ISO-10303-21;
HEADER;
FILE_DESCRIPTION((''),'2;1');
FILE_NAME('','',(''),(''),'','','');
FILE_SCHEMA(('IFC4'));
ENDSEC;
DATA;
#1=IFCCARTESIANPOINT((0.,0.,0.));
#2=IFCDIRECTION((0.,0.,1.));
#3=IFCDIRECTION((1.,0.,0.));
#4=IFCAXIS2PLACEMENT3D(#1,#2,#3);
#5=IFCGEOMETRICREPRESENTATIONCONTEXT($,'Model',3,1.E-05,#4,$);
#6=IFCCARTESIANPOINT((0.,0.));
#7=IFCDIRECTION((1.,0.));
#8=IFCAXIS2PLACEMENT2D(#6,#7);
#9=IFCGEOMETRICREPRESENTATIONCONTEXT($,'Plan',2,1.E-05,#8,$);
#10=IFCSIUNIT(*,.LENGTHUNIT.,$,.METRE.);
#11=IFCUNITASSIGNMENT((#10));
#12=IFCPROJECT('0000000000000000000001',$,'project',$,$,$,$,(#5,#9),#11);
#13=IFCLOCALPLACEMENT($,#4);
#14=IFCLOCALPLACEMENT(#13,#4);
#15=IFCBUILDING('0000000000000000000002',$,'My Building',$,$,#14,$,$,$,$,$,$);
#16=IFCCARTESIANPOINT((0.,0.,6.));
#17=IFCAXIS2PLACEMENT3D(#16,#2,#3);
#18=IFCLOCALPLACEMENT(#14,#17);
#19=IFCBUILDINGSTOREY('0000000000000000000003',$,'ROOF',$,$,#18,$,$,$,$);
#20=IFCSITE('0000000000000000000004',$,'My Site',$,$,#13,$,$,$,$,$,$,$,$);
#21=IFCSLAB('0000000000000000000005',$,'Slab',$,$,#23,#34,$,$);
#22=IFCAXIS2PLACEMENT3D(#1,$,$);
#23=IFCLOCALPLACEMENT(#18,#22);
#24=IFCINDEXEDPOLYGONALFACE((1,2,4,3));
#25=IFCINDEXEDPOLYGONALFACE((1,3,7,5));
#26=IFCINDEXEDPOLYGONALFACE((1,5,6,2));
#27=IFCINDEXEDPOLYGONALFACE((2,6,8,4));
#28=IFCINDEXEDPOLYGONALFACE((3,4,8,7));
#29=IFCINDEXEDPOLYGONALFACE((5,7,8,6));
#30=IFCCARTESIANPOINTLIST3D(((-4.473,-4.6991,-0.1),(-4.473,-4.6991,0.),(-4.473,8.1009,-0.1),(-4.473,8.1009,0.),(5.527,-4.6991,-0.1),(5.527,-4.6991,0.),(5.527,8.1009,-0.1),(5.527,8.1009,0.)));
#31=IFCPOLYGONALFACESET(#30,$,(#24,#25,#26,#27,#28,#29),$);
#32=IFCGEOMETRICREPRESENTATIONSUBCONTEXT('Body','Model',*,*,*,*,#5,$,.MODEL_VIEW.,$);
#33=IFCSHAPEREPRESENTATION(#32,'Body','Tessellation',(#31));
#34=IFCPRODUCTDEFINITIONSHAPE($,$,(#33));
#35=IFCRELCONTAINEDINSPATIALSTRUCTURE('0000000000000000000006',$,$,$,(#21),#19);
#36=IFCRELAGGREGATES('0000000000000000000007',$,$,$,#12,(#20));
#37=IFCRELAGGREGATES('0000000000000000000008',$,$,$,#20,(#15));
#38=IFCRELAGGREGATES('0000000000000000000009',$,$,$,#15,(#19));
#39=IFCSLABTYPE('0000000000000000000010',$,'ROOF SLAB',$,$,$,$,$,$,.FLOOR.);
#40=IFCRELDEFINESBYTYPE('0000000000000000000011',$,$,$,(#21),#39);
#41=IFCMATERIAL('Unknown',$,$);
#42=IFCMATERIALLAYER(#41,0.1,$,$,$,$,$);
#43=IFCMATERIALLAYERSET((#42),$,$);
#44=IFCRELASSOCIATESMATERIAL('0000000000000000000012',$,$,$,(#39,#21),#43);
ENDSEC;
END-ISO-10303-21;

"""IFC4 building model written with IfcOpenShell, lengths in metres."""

from ifc_helpers import new_model, si_unit, frame, origin_with_axes, origin_2d_with_axis, place, context, subcontext, project, spatial, indexed_curve, outline, extrude, material, layer, layer_set, layer_usage, type_object, element, save


model = new_model("IFC4")

# Units and contexts
model_context = context("Model", 3, precision=1e-05, world=origin_with_axes())
plan_context = context("Plan", 2, precision=1e-05, world=origin_2d_with_axis())
body_context = subcontext(model_context, "Body", "Model", "MODEL_VIEW")
ifc_project = project(units=[si_unit("LENGTHUNIT", "METRE")], contexts=[model_context, plan_context])

# Site, building, storey
site_placement = place(None, origin_with_axes())
site = spatial("IfcSite", under=ifc_project, at=site_placement, Name="My Site")
building_placement = place(site_placement, origin_with_axes())
building = spatial("IfcBuilding", under=site, at=building_placement, Name="My Building")
storey_placement = place(building_placement, frame((0.0, 0.0, 6.0), z_axis=(0.0, 0.0, 1.0), x_axis=(1.0, 0.0, 0.0)))
storey = spatial("IfcBuildingStorey", under=building, at=storey_placement, Name="ROOF")

# Slab
ifc_material = material(Name="Unknown")
ifc_layer = layer(ifc_material, 0.1)
ifc_layer_set = layer_set([ifc_layer])
ifc_layer_usage = layer_usage(ifc_layer_set, "AXIS3", "POSITIVE", -0.1)
slab_type = type_object("IfcSlabType", Name="ROOF SLAB", PredefinedType="FLOOR", material=ifc_layer_set)
slab_placement = place(storey_placement, frame((-4.473, 8.1009, 0.0), z_axis=(0.0, 0.0, 1.0), x_axis=(1.0, 0.0, 0.0)))
element("IfcSlab", 1, at=slab_placement, inside=storey, type_object=slab_type, material=ifc_layer_usage, Name="Slab", context=body_context, shape_type="SweptSolid", body=[
    extrude(outline(indexed_curve([(0.0, 0.0), (0.0, -12.8), (10.0, -12.8), (10.0, 0.0), (0.0, 0.0)])), frame((0.0, 0.0, -0.1), z_axis=(0.0, 0.0, 1.0), x_axis=(1.0, 0.0, 0.0)), (0.0, 0.0, 1.0), 0.1),
])

save(model, "model.ifc")
